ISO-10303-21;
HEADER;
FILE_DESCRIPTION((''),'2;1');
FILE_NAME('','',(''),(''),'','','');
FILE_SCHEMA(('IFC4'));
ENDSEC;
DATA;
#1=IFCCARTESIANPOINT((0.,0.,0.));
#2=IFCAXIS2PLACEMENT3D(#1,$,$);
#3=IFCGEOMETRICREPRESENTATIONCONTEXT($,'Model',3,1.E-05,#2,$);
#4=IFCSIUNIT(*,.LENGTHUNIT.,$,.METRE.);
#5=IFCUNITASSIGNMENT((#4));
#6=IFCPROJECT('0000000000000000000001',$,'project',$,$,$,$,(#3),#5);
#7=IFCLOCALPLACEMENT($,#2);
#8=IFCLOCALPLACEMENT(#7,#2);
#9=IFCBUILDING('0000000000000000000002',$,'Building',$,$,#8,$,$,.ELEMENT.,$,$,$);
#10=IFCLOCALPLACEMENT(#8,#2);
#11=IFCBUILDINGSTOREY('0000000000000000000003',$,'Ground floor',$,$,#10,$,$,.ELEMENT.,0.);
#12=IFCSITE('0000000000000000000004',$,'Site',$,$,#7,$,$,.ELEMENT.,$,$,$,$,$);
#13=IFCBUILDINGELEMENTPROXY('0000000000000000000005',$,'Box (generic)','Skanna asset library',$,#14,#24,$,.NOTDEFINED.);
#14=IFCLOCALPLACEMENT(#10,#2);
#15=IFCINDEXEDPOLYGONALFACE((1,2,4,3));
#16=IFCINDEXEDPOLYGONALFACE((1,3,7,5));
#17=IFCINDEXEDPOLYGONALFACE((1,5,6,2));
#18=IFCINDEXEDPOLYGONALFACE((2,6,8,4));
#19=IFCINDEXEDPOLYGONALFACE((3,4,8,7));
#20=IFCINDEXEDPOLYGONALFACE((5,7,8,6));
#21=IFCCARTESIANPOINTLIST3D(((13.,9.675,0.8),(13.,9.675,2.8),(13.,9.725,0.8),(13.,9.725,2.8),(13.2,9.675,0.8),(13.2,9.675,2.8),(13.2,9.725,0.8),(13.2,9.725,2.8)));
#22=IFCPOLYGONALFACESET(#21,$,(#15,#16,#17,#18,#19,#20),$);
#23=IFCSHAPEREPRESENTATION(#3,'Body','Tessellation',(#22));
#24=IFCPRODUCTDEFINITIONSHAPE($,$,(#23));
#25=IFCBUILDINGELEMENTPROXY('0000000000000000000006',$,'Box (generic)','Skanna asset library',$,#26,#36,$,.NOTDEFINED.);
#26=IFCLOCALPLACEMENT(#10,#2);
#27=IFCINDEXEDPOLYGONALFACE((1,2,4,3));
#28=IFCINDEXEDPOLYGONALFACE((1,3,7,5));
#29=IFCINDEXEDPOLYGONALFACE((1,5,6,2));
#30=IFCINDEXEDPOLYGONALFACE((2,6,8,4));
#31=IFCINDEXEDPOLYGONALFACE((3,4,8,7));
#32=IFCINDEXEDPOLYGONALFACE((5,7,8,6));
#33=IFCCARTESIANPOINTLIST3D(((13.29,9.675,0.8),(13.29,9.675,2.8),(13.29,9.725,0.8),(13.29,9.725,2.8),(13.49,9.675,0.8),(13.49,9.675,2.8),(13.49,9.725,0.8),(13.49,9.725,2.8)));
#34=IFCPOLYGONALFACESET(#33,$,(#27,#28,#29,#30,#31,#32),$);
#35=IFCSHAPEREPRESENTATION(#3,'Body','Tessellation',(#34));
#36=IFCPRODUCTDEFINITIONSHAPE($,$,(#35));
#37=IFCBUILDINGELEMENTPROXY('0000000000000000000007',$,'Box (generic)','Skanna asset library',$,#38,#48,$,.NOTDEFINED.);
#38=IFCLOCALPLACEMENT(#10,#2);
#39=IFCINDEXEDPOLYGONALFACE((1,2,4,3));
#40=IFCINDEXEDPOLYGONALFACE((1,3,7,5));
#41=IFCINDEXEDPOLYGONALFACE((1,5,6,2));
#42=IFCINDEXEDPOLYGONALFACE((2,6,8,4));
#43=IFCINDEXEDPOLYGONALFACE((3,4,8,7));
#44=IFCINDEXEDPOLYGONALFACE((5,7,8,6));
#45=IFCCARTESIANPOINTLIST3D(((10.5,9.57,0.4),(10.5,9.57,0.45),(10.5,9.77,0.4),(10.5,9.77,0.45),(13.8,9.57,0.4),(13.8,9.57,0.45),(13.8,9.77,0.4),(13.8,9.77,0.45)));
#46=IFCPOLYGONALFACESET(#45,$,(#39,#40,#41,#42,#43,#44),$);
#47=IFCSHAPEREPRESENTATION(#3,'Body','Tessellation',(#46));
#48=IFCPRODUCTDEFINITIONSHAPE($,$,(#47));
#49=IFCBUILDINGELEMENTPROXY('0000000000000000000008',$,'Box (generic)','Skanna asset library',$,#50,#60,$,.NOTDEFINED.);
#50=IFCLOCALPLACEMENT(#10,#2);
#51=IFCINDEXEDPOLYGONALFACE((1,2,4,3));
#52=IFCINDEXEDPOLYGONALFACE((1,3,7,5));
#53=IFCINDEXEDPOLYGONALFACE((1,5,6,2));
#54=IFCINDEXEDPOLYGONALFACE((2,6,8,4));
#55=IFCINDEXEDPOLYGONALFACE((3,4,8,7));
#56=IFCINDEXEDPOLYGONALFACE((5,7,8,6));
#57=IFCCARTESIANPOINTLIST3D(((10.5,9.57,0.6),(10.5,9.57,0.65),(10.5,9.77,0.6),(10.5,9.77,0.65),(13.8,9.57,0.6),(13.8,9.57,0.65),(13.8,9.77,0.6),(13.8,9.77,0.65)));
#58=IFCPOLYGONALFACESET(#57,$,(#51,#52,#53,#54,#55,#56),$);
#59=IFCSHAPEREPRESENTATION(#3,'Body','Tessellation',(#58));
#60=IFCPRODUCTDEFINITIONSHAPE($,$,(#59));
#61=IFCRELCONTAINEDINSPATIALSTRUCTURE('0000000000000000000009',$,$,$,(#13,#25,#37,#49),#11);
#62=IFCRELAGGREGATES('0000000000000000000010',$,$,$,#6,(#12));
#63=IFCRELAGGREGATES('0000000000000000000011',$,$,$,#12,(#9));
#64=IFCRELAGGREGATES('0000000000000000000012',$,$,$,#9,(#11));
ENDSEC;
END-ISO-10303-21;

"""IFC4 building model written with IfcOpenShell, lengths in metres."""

from ifc_helpers import new_model, si_unit, frame, origin, origin_2d, place, context, project, spatial, rectangle, extrude, element, save


model = new_model("IFC4")

# Units and contexts
model_context = context("Model", 3, precision=1e-05, world=origin())
ifc_project = project(units=[si_unit("LENGTHUNIT", "METRE")], contexts=[model_context])

# Site, building, storey
site_placement = place(None, origin())
site = spatial("IfcSite", under=ifc_project, at=site_placement, Name="Site", CompositionType="ELEMENT")
building_placement = place(site_placement, origin())
building = spatial("IfcBuilding", under=site, at=building_placement, Name="Building", CompositionType="ELEMENT")
storey_placement = place(building_placement, origin())
storey = spatial("IfcBuildingStorey", under=building, at=storey_placement, Name="Ground floor", CompositionType="ELEMENT", Elevation=0.0)

# Building element proxies
for number, where, z_axis, x_axis, name in (
    (1, (13.1, 9.7, 0.8), (0.0, 0.0, 1.0), (1.0, 0.0, 0.0), "Box (generic)"),
    (2, (13.39, 9.7, 0.8), (0.0, 0.0, 1.0), (1.0, 0.0, 0.0), "Box (generic)"),
):
    element("IfcBuildingElementProxy", number, at=place(storey_placement, frame(where, z_axis=z_axis, x_axis=x_axis)), inside=storey, Name=name, Description="Skanna asset library", PredefinedType="NOTDEFINED", context=model_context, shape_type="SweptSolid", body=[
        extrude(rectangle(XDim=0.2, YDim=0.05, at=origin_2d()), origin(), (0.0, 0.0, 1.0), 2.0),
    ])
for number, where, z_axis, x_axis, name in (
    (3, (12.15, 9.67, 0.4), (0.0, 0.0, 1.0), (1.0, 0.0, 0.0), "Box (generic)"),
    (4, (12.15, 9.67, 0.6), (0.0, 0.0, 1.0), (1.0, 0.0, 0.0), "Box (generic)"),
):
    element("IfcBuildingElementProxy", number, at=place(storey_placement, frame(where, z_axis=z_axis, x_axis=x_axis)), inside=storey, Name=name, Description="Skanna asset library", PredefinedType="NOTDEFINED", context=model_context, shape_type="SweptSolid", body=[
        extrude(rectangle(XDim=3.3, YDim=0.2, at=origin_2d()), origin(), (0.0, 0.0, 1.0), 0.05),
    ])

save(model, "model.ifc")
